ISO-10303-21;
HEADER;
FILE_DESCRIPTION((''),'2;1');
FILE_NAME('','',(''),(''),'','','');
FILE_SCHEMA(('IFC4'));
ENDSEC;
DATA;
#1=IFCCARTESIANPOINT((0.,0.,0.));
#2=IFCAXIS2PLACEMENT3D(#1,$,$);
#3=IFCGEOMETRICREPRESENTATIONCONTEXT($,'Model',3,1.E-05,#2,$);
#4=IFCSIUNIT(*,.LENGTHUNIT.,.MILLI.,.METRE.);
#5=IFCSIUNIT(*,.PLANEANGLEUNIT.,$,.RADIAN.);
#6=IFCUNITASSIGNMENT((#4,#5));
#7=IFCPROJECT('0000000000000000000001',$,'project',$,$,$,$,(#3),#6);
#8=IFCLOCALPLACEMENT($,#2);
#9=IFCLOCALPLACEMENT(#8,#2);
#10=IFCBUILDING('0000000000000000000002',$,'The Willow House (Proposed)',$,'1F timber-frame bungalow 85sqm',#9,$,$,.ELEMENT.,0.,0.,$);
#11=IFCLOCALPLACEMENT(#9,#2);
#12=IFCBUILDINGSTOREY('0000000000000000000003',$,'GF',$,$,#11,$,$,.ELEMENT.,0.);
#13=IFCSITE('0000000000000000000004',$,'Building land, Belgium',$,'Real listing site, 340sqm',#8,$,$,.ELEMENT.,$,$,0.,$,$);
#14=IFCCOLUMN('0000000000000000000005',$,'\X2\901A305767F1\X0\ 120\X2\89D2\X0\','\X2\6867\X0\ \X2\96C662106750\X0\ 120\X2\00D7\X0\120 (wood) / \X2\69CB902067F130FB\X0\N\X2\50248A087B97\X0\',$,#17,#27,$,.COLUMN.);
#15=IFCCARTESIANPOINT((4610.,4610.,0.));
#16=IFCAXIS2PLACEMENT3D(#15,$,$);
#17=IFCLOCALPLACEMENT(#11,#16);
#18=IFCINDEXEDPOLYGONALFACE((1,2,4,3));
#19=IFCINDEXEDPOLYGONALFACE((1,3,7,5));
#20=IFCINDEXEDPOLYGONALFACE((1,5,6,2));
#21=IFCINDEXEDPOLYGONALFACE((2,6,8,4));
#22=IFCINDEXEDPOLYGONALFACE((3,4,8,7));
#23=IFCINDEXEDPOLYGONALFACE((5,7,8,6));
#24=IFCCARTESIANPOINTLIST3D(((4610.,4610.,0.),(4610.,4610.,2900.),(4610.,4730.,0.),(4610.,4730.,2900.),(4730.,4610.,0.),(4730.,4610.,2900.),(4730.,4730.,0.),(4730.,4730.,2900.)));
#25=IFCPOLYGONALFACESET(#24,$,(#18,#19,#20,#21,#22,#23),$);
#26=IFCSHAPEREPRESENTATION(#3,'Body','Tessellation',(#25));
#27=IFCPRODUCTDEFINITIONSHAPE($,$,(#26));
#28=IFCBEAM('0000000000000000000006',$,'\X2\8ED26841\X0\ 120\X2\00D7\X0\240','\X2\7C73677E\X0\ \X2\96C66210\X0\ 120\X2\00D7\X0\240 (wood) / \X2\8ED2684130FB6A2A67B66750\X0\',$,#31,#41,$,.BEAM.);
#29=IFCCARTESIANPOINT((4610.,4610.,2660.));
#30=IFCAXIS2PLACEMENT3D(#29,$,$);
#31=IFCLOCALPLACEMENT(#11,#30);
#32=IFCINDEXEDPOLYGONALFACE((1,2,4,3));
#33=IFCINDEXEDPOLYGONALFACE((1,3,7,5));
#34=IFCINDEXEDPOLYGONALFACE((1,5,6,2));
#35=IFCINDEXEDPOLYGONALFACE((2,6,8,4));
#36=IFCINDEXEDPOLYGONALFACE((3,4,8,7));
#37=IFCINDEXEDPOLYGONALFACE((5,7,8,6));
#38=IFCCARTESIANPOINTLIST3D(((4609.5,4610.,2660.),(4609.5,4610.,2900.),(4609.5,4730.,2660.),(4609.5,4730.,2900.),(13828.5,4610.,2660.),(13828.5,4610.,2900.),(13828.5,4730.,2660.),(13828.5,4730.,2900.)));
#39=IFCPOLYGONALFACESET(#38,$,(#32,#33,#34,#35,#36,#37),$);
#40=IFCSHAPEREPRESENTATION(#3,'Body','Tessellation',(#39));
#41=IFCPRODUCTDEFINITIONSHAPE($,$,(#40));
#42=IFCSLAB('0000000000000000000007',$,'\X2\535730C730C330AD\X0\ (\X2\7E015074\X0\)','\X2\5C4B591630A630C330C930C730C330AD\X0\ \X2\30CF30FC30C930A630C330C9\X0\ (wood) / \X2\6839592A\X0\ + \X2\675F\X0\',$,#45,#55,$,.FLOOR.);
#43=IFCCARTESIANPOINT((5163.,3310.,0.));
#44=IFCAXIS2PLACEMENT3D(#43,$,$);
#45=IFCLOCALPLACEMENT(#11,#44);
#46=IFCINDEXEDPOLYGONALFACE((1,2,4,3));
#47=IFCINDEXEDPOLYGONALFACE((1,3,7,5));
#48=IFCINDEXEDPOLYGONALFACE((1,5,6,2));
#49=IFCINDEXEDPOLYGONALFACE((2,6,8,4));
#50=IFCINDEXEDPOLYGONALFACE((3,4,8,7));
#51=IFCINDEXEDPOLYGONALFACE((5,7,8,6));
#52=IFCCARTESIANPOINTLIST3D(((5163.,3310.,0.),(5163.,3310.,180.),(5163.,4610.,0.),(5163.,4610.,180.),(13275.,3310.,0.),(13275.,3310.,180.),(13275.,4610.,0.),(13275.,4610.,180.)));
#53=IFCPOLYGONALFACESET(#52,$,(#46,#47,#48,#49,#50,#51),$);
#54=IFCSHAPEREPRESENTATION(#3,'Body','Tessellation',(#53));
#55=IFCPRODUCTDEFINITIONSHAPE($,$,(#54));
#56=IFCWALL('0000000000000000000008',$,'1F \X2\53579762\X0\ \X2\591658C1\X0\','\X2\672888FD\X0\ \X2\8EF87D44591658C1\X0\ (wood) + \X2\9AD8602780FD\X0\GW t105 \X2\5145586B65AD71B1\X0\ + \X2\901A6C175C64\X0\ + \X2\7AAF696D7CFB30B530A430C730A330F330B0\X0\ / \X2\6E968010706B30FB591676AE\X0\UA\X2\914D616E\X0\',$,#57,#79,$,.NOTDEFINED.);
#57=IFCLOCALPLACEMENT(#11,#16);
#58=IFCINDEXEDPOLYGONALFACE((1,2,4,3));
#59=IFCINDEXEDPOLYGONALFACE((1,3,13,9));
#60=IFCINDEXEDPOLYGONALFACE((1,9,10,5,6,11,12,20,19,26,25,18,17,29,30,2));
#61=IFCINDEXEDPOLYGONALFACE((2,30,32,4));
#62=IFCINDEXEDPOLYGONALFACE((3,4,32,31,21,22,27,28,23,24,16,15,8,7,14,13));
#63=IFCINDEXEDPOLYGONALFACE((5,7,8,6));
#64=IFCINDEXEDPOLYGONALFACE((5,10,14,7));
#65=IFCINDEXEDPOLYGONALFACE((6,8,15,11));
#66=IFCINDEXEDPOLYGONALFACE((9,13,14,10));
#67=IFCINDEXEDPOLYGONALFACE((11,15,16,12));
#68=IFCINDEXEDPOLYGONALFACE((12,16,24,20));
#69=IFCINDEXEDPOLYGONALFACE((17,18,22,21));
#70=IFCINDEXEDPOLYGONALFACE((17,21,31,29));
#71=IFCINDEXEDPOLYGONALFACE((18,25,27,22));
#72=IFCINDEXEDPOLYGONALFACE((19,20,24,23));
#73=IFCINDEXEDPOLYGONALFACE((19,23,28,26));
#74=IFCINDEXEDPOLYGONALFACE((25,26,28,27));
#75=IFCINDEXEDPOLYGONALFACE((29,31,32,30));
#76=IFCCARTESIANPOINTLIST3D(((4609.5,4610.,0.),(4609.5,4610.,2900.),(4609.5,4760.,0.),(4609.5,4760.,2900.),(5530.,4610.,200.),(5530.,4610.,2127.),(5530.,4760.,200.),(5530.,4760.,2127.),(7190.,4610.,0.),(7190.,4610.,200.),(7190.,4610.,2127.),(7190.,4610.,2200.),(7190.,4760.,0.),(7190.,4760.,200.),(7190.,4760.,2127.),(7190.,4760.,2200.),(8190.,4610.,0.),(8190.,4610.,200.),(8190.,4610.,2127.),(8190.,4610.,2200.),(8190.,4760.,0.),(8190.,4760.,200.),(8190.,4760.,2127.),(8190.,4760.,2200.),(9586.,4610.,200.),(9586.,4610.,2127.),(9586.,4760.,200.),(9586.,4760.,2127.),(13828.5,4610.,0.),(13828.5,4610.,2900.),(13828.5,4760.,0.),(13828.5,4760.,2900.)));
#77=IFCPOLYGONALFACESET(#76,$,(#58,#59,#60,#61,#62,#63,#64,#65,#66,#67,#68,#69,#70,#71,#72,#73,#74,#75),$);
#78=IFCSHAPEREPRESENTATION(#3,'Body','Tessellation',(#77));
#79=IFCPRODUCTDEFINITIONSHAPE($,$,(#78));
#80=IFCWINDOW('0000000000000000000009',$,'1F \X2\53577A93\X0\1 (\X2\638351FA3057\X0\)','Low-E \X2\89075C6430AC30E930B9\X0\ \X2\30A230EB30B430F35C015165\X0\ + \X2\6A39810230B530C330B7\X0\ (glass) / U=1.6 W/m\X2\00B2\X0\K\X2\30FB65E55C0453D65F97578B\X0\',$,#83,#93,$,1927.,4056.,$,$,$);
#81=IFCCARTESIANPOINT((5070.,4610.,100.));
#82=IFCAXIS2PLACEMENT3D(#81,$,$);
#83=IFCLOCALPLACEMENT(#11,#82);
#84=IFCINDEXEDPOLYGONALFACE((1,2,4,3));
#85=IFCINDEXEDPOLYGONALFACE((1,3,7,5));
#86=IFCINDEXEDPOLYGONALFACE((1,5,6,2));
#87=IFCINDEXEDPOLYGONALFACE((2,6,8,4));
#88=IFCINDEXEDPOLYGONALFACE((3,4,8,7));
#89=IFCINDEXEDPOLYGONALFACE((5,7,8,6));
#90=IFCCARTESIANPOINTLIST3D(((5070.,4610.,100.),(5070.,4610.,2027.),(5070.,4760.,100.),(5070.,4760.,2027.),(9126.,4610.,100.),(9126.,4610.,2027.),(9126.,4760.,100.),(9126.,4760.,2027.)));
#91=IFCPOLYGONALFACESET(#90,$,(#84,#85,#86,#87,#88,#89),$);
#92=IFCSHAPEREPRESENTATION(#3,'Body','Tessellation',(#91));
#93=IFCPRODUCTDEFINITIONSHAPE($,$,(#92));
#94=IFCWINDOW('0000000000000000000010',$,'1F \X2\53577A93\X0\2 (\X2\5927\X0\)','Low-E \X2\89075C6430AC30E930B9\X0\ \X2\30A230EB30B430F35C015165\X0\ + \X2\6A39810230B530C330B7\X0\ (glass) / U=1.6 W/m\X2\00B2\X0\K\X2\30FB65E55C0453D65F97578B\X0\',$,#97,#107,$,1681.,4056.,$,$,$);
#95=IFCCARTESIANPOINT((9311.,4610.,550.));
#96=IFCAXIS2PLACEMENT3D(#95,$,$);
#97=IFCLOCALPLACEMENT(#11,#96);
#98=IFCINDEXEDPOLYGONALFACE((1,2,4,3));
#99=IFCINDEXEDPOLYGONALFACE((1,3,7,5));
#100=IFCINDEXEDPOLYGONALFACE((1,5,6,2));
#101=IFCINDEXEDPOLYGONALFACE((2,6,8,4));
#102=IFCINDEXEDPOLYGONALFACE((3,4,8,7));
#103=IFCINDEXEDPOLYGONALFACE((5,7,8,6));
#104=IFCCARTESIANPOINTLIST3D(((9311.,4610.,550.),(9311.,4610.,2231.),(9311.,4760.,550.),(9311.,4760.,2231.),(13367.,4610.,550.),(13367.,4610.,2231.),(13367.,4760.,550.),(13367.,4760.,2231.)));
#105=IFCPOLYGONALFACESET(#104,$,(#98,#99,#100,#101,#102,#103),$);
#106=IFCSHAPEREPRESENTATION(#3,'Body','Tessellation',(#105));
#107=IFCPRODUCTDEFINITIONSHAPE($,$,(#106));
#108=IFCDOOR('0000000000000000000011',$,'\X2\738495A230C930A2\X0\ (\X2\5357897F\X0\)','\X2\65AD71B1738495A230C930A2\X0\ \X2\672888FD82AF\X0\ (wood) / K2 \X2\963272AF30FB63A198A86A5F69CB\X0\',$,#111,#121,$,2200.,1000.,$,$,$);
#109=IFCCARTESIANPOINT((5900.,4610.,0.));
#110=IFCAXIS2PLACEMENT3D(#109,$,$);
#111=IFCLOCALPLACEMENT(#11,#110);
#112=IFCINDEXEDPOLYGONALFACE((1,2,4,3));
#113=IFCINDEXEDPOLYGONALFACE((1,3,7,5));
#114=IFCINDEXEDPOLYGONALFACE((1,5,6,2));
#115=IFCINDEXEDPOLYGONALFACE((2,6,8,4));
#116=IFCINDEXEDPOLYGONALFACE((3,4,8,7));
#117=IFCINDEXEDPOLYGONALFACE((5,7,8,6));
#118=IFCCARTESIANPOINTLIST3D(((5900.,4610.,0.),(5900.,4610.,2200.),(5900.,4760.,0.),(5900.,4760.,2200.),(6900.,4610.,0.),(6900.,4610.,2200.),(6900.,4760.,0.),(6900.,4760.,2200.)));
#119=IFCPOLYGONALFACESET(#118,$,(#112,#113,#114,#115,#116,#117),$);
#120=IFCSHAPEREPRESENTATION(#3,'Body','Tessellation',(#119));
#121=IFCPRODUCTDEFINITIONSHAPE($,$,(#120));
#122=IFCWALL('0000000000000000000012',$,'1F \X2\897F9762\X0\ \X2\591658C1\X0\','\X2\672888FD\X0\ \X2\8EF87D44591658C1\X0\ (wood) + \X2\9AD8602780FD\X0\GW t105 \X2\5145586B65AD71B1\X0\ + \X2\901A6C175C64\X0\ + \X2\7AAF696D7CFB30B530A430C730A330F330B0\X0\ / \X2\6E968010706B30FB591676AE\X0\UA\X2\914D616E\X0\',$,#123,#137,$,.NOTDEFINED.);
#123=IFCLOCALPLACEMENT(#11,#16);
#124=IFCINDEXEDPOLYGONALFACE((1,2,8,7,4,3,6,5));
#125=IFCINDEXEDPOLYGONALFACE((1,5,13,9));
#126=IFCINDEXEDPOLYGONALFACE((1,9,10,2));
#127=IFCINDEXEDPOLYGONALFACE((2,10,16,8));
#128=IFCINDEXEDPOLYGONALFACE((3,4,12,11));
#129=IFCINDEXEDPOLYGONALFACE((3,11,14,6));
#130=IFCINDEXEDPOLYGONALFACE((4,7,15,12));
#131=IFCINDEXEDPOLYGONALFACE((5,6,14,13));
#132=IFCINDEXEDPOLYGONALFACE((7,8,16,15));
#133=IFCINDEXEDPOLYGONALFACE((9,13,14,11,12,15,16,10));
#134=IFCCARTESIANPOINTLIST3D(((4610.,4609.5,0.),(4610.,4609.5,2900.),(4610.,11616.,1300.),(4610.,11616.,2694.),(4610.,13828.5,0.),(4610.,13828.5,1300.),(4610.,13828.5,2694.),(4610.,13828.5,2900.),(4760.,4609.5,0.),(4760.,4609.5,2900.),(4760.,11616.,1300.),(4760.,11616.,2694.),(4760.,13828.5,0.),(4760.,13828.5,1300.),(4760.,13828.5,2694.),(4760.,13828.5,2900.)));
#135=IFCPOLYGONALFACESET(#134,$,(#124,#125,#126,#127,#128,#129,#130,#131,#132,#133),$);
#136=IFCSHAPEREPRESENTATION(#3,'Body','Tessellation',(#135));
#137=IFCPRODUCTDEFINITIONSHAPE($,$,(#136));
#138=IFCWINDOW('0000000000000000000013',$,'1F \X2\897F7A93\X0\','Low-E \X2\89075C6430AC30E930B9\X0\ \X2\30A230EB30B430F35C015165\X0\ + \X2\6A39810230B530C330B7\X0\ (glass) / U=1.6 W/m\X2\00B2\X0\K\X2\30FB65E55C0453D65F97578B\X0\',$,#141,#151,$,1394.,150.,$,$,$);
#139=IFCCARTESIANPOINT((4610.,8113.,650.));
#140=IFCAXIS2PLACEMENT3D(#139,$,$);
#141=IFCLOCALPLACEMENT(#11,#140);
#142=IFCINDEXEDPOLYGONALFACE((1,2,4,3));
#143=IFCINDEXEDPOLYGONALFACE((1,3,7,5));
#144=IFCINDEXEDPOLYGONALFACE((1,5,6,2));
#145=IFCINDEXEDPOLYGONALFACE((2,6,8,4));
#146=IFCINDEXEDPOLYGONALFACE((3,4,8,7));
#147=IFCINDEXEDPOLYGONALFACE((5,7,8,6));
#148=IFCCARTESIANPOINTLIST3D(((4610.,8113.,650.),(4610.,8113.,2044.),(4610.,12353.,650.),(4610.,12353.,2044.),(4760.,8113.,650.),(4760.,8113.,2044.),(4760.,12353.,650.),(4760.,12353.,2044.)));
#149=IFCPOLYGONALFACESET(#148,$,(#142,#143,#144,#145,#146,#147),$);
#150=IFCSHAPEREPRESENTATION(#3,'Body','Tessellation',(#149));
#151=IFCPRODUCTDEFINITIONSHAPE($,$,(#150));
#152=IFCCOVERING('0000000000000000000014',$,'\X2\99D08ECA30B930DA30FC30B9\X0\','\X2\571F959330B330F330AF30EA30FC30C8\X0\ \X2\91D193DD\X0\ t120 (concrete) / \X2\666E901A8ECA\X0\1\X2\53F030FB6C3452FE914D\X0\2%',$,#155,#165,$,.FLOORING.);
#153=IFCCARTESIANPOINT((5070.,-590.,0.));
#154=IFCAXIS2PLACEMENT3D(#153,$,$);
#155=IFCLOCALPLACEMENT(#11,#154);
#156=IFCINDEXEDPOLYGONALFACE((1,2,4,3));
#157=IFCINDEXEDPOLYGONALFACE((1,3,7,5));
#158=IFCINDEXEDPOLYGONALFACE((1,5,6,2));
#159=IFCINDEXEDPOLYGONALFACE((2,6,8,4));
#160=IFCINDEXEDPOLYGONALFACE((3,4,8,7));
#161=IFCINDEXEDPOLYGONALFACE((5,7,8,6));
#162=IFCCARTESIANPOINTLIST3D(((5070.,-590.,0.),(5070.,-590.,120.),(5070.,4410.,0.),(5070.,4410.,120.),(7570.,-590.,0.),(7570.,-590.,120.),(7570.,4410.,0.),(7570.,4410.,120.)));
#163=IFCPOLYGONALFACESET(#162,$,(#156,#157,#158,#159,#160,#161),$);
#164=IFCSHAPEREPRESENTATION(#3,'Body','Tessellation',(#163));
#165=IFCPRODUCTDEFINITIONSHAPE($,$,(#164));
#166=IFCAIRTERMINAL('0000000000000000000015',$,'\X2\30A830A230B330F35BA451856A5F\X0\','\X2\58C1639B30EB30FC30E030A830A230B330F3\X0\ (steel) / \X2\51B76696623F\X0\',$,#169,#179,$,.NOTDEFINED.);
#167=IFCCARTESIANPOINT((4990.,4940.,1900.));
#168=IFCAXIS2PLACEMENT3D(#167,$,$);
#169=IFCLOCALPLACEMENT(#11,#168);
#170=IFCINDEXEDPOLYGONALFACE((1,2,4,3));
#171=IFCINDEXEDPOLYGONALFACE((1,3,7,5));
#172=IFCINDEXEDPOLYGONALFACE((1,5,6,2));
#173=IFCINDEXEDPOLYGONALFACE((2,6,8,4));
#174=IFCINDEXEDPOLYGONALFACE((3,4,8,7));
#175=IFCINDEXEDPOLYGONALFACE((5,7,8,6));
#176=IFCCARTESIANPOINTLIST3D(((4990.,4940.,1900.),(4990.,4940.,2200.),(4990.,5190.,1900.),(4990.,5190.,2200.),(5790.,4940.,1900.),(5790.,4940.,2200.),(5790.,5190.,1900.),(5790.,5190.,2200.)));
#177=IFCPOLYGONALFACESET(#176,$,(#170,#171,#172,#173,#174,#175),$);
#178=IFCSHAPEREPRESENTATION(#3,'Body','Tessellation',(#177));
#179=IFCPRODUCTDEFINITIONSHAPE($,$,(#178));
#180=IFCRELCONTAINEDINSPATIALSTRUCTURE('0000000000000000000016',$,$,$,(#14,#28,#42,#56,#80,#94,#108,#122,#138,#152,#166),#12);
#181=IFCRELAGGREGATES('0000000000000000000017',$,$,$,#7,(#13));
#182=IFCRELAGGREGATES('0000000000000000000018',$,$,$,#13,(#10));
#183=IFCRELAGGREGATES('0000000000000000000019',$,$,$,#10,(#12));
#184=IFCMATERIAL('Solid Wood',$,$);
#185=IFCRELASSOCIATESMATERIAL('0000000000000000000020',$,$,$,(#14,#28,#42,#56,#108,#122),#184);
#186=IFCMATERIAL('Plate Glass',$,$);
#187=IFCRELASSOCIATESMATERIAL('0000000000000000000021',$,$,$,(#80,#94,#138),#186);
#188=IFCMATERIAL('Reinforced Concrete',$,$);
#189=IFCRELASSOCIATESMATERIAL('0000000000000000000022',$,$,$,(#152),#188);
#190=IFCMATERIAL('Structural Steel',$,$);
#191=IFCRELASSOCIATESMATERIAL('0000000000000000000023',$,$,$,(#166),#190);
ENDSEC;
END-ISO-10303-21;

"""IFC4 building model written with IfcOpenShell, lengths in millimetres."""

from ifc_helpers import new_model, si_unit, frame, frame_2d, origin, place, context, project, spatial, rectangle, extrude, material, element, fill, save


model = new_model("IFC4")

# Units and contexts
model_context = context("Model", 3, precision=1e-05, world=origin())
ifc_project = project(units=[si_unit("LENGTHUNIT", "METRE", prefix="MILLI"), si_unit("PLANEANGLEUNIT", "RADIAN")], contexts=[model_context])

# Site, building, storey
site_placement = place(None, origin())
site = spatial("IfcSite", under=ifc_project, at=site_placement, Name="Building land, Belgium", ObjectType="Real listing site, 340sqm", CompositionType="ELEMENT", RefElevation=0.0)
building_placement = place(site_placement, origin())
building = spatial("IfcBuilding", under=site, at=building_placement, Name="The Willow House (Proposed)", ObjectType="1F timber-frame bungalow 85sqm", CompositionType="ELEMENT", ElevationOfRefHeight=0.0, ElevationOfTerrain=0.0)
storey_placement = place(building_placement, origin())
storey = spatial("IfcBuildingStorey", under=building, at=storey_placement, Name="GF", CompositionType="ELEMENT", Elevation=0.0)

# Column
ifc_material_1 = material(Name="Solid Wood")
column_1_placement = place(storey_placement, frame((4610.0, 4610.0, 0.0)))
element("IfcColumn", 1, at=column_1_placement, inside=storey, material=ifc_material_1, Name="通し柱 120角", Description="桧 集成材 120×120 (wood) / 構造柱・N値計算", PredefinedType="COLUMN", context=model_context, shape_type="SweptSolid", body=[
    extrude(rectangle(XDim=120.0, YDim=120.0, at=frame_2d((60.0, 60.0))), frame((4610.0, 4610.0, 0.0)), (0.0, 0.0, 1.0), 2900.0),
])

# Beam
beam_1_placement = place(storey_placement, frame((4610.0, 4610.0, 2660.0)))
element("IfcBeam", 2, at=beam_1_placement, inside=storey, material=ifc_material_1, Name="軒桁 120×240", Description="米松 集成 120×240 (wood) / 軒桁・横架材", PredefinedType="BEAM", context=model_context, shape_type="SweptSolid", body=[
    extrude(rectangle(XDim=9219.0, YDim=120.0, at=frame_2d((4609.0, 60.0))), frame((4610.0, 4610.0, 2660.0)), (0.0, 0.0, 1.0), 240.0),
])

# Slab
ifc_material_2 = material(Name="Reinforced Concrete")
slab_1_placement = place(storey_placement, frame((5163.0, 3310.0, 0.0)))
element("IfcSlab", 3, at=slab_1_placement, inside=storey, material=ifc_material_1, Name="南デッキ (縁側)", Description="屋外ウッドデッキ ハードウッド (wood) / 根太 + 束", PredefinedType="FLOOR", context=model_context, shape_type="SweptSolid", body=[
    extrude(rectangle(XDim=8112.0, YDim=1300.0, at=frame_2d((4056.0, 650.0))), frame((5163.0, 3310.0, 0.0)), (0.0, 0.0, 1.0), 180.0),
])

# Wall, openings, windows, door
wall_1_placement = place(storey_placement, frame((4610.0, 4610.0, 0.0)))
wall_1 = element("IfcWall", 4, at=wall_1_placement, inside=storey, material=ifc_material_1, Name="1F 南面 外壁", Description="木製 軸組外壁 (wood) + 高性能GW t105 充填断熱 + 通気層 + 窯業系サイディング / 準耐火・外皮UA配慮", PredefinedType="NOTDEFINED", context=model_context, shape_type="SweptSolid", body=[
    extrude(rectangle(XDim=9219.0, YDim=150.0, at=frame_2d((4609.0, 75.0))), frame((4610.0, 4610.0, 0.0)), (0.0, 0.0, 1.0), 2900.0),
])
opening_1_placement = place(storey_placement, frame((5070.0, 4610.0, 100.0)))
opening_1 = element("IfcOpeningElement", 5, at=opening_1_placement, cuts=wall_1, PredefinedType="NOTDEFINED", context=model_context, shape_type="SweptSolid", body=[
    extrude(rectangle(XDim=4056.0, YDim=150.0, at=frame_2d((2028.0, 75.0))), frame((5070.0, 4610.0, 100.0)), (0.0, 0.0, 1.0), 1927.0),
])
opening_2_placement = place(storey_placement, frame((9311.0, 4610.0, 550.0)))
opening_2 = element("IfcOpeningElement", 6, at=opening_2_placement, cuts=wall_1, PredefinedType="NOTDEFINED", context=model_context, shape_type="SweptSolid", body=[
    extrude(rectangle(XDim=4056.0, YDim=150.0, at=frame_2d((2028.0, 75.0))), frame((9311.0, 4610.0, 550.0)), (0.0, 0.0, 1.0), 1681.0),
])
opening_3_placement = place(storey_placement, frame((5900.0, 4610.0, 0.0)))
opening_3 = element("IfcOpeningElement", 7, at=opening_3_placement, cuts=wall_1, PredefinedType="NOTDEFINED", context=model_context, shape_type="SweptSolid", body=[
    extrude(rectangle(XDim=1000.0, YDim=150.0, at=frame_2d((500.0, 75.0))), frame((5900.0, 4610.0, 0.0)), (0.0, 0.0, 1.0), 2200.0),
])
ifc_material_3 = material(Name="Plate Glass")
window_1_placement = place(storey_placement, frame((5070.0, 4610.0, 100.0)))
window_1 = element("IfcWindow", 8, at=window_1_placement, inside=storey, material=ifc_material_3, Name="1F 南窓1 (掃出し)", Description="Low-E 複層ガラス アルゴン封入 + 樹脂サッシ (glass) / U=1.6 W/m²K・日射取得型", OverallHeight=1927.0, OverallWidth=4056.0, context=model_context, shape_type="SweptSolid", body=[
    extrude(rectangle(XDim=4056.0, YDim=150.0, at=frame_2d((2028.0, 75.0))), frame((5070.0, 4610.0, 100.0)), (0.0, 0.0, 1.0), 1927.0),
])
fill(opening_1, window_1)
window_2_placement = place(storey_placement, frame((9311.0, 4610.0, 550.0)))
window_2 = element("IfcWindow", 9, at=window_2_placement, inside=storey, material=ifc_material_3, Name="1F 南窓2 (大)", Description="Low-E 複層ガラス アルゴン封入 + 樹脂サッシ (glass) / U=1.6 W/m²K・日射取得型", OverallHeight=1681.0, OverallWidth=4056.0, context=model_context, shape_type="SweptSolid", body=[
    extrude(rectangle(XDim=4056.0, YDim=150.0, at=frame_2d((2028.0, 75.0))), frame((9311.0, 4610.0, 550.0)), (0.0, 0.0, 1.0), 1681.0),
])
fill(opening_2, window_2)
door_placement = place(storey_placement, frame((5900.0, 4610.0, 0.0)))
door = element("IfcDoor", 10, at=door_placement, inside=storey, material=ifc_material_1, Name="玄関ドア (南西)", Description="断熱玄関ドア 木製芯 (wood) / K2 防犯・採風機構", OverallHeight=2200.0, OverallWidth=1000.0, context=model_context, shape_type="SweptSolid", body=[
    extrude(rectangle(XDim=1000.0, YDim=150.0, at=frame_2d((500.0, 75.0))), frame((5900.0, 4610.0, 0.0)), (0.0, 0.0, 1.0), 2200.0),
])
fill(opening_3, door)

# Wall, opening, window
wall_2_placement = place(storey_placement, frame((4610.0, 4610.0, 0.0)))
wall_2 = element("IfcWall", 11, at=wall_2_placement, inside=storey, material=ifc_material_1, Name="1F 西面 外壁", Description="木製 軸組外壁 (wood) + 高性能GW t105 充填断熱 + 通気層 + 窯業系サイディング / 準耐火・外皮UA配慮", PredefinedType="NOTDEFINED", context=model_context, shape_type="SweptSolid", body=[
    extrude(rectangle(XDim=150.0, YDim=9219.0, at=frame_2d((75.0, 4609.0))), frame((4610.0, 4610.0, 0.0)), (0.0, 0.0, 1.0), 2900.0),
])
opening_4_placement = place(storey_placement, frame((4610.0, 8113.0, 650.0)))
opening_4 = element("IfcOpeningElement", 12, at=opening_4_placement, cuts=wall_2, PredefinedType="NOTDEFINED", context=model_context, shape_type="SweptSolid", body=[
    extrude(rectangle(XDim=150.0, YDim=4240.0, at=frame_2d((75.0, 2120.0))), frame((4610.0, 8113.0, 650.0)), (0.0, 0.0, 1.0), 1394.0),
])
window_3_placement = place(storey_placement, frame((4610.0, 8113.0, 650.0)))
window_3 = element("IfcWindow", 13, at=window_3_placement, inside=storey, material=ifc_material_3, Name="1F 西窓", Description="Low-E 複層ガラス アルゴン封入 + 樹脂サッシ (glass) / U=1.6 W/m²K・日射取得型", OverallHeight=1394.0, OverallWidth=150.0, context=model_context, shape_type="SweptSolid", body=[
    extrude(rectangle(XDim=150.0, YDim=4240.0, at=frame_2d((75.0, 2120.0))), frame((4610.0, 8113.0, 650.0)), (0.0, 0.0, 1.0), 1394.0),
])
fill(opening_4, window_3)

# Shared definitions
ifc_material_4 = material(Name="Structural Steel")

# Covering
covering_1_placement = place(storey_placement, frame((5070.0, -590.0, 0.0)))
element("IfcCovering", 14, at=covering_1_placement, inside=storey, material=ifc_material_2, Name="駐車スペース", Description="土間コンクリート 金鏝 t120 (concrete) / 普通車1台・水勾配2%", PredefinedType="FLOORING", context=model_context, shape_type="SweptSolid", body=[
    extrude(rectangle(XDim=2500.0, YDim=5000.0, at=frame_2d((1250.0, 2500.0))), frame((5070.0, -590.0, 0.0)), (0.0, 0.0, 1.0), 120.0),
])

# Air terminal
air_terminal_placement = place(storey_placement, frame((4990.0, 4940.0, 1900.0)))
element("IfcAirTerminal", 15, at=air_terminal_placement, inside=storey, material=ifc_material_4, Name="エアコン室内機", Description="壁掛ルームエアコン (steel) / 冷暖房", PredefinedType="NOTDEFINED", context=model_context, shape_type="SweptSolid", body=[
    extrude(rectangle(XDim=800.0, YDim=250.0, at=frame_2d((400.0, 125.0))), frame((4990.0, 4940.0, 1900.0)), (0.0, 0.0, 1.0), 300.0),
])

save(model, "model.ifc")
